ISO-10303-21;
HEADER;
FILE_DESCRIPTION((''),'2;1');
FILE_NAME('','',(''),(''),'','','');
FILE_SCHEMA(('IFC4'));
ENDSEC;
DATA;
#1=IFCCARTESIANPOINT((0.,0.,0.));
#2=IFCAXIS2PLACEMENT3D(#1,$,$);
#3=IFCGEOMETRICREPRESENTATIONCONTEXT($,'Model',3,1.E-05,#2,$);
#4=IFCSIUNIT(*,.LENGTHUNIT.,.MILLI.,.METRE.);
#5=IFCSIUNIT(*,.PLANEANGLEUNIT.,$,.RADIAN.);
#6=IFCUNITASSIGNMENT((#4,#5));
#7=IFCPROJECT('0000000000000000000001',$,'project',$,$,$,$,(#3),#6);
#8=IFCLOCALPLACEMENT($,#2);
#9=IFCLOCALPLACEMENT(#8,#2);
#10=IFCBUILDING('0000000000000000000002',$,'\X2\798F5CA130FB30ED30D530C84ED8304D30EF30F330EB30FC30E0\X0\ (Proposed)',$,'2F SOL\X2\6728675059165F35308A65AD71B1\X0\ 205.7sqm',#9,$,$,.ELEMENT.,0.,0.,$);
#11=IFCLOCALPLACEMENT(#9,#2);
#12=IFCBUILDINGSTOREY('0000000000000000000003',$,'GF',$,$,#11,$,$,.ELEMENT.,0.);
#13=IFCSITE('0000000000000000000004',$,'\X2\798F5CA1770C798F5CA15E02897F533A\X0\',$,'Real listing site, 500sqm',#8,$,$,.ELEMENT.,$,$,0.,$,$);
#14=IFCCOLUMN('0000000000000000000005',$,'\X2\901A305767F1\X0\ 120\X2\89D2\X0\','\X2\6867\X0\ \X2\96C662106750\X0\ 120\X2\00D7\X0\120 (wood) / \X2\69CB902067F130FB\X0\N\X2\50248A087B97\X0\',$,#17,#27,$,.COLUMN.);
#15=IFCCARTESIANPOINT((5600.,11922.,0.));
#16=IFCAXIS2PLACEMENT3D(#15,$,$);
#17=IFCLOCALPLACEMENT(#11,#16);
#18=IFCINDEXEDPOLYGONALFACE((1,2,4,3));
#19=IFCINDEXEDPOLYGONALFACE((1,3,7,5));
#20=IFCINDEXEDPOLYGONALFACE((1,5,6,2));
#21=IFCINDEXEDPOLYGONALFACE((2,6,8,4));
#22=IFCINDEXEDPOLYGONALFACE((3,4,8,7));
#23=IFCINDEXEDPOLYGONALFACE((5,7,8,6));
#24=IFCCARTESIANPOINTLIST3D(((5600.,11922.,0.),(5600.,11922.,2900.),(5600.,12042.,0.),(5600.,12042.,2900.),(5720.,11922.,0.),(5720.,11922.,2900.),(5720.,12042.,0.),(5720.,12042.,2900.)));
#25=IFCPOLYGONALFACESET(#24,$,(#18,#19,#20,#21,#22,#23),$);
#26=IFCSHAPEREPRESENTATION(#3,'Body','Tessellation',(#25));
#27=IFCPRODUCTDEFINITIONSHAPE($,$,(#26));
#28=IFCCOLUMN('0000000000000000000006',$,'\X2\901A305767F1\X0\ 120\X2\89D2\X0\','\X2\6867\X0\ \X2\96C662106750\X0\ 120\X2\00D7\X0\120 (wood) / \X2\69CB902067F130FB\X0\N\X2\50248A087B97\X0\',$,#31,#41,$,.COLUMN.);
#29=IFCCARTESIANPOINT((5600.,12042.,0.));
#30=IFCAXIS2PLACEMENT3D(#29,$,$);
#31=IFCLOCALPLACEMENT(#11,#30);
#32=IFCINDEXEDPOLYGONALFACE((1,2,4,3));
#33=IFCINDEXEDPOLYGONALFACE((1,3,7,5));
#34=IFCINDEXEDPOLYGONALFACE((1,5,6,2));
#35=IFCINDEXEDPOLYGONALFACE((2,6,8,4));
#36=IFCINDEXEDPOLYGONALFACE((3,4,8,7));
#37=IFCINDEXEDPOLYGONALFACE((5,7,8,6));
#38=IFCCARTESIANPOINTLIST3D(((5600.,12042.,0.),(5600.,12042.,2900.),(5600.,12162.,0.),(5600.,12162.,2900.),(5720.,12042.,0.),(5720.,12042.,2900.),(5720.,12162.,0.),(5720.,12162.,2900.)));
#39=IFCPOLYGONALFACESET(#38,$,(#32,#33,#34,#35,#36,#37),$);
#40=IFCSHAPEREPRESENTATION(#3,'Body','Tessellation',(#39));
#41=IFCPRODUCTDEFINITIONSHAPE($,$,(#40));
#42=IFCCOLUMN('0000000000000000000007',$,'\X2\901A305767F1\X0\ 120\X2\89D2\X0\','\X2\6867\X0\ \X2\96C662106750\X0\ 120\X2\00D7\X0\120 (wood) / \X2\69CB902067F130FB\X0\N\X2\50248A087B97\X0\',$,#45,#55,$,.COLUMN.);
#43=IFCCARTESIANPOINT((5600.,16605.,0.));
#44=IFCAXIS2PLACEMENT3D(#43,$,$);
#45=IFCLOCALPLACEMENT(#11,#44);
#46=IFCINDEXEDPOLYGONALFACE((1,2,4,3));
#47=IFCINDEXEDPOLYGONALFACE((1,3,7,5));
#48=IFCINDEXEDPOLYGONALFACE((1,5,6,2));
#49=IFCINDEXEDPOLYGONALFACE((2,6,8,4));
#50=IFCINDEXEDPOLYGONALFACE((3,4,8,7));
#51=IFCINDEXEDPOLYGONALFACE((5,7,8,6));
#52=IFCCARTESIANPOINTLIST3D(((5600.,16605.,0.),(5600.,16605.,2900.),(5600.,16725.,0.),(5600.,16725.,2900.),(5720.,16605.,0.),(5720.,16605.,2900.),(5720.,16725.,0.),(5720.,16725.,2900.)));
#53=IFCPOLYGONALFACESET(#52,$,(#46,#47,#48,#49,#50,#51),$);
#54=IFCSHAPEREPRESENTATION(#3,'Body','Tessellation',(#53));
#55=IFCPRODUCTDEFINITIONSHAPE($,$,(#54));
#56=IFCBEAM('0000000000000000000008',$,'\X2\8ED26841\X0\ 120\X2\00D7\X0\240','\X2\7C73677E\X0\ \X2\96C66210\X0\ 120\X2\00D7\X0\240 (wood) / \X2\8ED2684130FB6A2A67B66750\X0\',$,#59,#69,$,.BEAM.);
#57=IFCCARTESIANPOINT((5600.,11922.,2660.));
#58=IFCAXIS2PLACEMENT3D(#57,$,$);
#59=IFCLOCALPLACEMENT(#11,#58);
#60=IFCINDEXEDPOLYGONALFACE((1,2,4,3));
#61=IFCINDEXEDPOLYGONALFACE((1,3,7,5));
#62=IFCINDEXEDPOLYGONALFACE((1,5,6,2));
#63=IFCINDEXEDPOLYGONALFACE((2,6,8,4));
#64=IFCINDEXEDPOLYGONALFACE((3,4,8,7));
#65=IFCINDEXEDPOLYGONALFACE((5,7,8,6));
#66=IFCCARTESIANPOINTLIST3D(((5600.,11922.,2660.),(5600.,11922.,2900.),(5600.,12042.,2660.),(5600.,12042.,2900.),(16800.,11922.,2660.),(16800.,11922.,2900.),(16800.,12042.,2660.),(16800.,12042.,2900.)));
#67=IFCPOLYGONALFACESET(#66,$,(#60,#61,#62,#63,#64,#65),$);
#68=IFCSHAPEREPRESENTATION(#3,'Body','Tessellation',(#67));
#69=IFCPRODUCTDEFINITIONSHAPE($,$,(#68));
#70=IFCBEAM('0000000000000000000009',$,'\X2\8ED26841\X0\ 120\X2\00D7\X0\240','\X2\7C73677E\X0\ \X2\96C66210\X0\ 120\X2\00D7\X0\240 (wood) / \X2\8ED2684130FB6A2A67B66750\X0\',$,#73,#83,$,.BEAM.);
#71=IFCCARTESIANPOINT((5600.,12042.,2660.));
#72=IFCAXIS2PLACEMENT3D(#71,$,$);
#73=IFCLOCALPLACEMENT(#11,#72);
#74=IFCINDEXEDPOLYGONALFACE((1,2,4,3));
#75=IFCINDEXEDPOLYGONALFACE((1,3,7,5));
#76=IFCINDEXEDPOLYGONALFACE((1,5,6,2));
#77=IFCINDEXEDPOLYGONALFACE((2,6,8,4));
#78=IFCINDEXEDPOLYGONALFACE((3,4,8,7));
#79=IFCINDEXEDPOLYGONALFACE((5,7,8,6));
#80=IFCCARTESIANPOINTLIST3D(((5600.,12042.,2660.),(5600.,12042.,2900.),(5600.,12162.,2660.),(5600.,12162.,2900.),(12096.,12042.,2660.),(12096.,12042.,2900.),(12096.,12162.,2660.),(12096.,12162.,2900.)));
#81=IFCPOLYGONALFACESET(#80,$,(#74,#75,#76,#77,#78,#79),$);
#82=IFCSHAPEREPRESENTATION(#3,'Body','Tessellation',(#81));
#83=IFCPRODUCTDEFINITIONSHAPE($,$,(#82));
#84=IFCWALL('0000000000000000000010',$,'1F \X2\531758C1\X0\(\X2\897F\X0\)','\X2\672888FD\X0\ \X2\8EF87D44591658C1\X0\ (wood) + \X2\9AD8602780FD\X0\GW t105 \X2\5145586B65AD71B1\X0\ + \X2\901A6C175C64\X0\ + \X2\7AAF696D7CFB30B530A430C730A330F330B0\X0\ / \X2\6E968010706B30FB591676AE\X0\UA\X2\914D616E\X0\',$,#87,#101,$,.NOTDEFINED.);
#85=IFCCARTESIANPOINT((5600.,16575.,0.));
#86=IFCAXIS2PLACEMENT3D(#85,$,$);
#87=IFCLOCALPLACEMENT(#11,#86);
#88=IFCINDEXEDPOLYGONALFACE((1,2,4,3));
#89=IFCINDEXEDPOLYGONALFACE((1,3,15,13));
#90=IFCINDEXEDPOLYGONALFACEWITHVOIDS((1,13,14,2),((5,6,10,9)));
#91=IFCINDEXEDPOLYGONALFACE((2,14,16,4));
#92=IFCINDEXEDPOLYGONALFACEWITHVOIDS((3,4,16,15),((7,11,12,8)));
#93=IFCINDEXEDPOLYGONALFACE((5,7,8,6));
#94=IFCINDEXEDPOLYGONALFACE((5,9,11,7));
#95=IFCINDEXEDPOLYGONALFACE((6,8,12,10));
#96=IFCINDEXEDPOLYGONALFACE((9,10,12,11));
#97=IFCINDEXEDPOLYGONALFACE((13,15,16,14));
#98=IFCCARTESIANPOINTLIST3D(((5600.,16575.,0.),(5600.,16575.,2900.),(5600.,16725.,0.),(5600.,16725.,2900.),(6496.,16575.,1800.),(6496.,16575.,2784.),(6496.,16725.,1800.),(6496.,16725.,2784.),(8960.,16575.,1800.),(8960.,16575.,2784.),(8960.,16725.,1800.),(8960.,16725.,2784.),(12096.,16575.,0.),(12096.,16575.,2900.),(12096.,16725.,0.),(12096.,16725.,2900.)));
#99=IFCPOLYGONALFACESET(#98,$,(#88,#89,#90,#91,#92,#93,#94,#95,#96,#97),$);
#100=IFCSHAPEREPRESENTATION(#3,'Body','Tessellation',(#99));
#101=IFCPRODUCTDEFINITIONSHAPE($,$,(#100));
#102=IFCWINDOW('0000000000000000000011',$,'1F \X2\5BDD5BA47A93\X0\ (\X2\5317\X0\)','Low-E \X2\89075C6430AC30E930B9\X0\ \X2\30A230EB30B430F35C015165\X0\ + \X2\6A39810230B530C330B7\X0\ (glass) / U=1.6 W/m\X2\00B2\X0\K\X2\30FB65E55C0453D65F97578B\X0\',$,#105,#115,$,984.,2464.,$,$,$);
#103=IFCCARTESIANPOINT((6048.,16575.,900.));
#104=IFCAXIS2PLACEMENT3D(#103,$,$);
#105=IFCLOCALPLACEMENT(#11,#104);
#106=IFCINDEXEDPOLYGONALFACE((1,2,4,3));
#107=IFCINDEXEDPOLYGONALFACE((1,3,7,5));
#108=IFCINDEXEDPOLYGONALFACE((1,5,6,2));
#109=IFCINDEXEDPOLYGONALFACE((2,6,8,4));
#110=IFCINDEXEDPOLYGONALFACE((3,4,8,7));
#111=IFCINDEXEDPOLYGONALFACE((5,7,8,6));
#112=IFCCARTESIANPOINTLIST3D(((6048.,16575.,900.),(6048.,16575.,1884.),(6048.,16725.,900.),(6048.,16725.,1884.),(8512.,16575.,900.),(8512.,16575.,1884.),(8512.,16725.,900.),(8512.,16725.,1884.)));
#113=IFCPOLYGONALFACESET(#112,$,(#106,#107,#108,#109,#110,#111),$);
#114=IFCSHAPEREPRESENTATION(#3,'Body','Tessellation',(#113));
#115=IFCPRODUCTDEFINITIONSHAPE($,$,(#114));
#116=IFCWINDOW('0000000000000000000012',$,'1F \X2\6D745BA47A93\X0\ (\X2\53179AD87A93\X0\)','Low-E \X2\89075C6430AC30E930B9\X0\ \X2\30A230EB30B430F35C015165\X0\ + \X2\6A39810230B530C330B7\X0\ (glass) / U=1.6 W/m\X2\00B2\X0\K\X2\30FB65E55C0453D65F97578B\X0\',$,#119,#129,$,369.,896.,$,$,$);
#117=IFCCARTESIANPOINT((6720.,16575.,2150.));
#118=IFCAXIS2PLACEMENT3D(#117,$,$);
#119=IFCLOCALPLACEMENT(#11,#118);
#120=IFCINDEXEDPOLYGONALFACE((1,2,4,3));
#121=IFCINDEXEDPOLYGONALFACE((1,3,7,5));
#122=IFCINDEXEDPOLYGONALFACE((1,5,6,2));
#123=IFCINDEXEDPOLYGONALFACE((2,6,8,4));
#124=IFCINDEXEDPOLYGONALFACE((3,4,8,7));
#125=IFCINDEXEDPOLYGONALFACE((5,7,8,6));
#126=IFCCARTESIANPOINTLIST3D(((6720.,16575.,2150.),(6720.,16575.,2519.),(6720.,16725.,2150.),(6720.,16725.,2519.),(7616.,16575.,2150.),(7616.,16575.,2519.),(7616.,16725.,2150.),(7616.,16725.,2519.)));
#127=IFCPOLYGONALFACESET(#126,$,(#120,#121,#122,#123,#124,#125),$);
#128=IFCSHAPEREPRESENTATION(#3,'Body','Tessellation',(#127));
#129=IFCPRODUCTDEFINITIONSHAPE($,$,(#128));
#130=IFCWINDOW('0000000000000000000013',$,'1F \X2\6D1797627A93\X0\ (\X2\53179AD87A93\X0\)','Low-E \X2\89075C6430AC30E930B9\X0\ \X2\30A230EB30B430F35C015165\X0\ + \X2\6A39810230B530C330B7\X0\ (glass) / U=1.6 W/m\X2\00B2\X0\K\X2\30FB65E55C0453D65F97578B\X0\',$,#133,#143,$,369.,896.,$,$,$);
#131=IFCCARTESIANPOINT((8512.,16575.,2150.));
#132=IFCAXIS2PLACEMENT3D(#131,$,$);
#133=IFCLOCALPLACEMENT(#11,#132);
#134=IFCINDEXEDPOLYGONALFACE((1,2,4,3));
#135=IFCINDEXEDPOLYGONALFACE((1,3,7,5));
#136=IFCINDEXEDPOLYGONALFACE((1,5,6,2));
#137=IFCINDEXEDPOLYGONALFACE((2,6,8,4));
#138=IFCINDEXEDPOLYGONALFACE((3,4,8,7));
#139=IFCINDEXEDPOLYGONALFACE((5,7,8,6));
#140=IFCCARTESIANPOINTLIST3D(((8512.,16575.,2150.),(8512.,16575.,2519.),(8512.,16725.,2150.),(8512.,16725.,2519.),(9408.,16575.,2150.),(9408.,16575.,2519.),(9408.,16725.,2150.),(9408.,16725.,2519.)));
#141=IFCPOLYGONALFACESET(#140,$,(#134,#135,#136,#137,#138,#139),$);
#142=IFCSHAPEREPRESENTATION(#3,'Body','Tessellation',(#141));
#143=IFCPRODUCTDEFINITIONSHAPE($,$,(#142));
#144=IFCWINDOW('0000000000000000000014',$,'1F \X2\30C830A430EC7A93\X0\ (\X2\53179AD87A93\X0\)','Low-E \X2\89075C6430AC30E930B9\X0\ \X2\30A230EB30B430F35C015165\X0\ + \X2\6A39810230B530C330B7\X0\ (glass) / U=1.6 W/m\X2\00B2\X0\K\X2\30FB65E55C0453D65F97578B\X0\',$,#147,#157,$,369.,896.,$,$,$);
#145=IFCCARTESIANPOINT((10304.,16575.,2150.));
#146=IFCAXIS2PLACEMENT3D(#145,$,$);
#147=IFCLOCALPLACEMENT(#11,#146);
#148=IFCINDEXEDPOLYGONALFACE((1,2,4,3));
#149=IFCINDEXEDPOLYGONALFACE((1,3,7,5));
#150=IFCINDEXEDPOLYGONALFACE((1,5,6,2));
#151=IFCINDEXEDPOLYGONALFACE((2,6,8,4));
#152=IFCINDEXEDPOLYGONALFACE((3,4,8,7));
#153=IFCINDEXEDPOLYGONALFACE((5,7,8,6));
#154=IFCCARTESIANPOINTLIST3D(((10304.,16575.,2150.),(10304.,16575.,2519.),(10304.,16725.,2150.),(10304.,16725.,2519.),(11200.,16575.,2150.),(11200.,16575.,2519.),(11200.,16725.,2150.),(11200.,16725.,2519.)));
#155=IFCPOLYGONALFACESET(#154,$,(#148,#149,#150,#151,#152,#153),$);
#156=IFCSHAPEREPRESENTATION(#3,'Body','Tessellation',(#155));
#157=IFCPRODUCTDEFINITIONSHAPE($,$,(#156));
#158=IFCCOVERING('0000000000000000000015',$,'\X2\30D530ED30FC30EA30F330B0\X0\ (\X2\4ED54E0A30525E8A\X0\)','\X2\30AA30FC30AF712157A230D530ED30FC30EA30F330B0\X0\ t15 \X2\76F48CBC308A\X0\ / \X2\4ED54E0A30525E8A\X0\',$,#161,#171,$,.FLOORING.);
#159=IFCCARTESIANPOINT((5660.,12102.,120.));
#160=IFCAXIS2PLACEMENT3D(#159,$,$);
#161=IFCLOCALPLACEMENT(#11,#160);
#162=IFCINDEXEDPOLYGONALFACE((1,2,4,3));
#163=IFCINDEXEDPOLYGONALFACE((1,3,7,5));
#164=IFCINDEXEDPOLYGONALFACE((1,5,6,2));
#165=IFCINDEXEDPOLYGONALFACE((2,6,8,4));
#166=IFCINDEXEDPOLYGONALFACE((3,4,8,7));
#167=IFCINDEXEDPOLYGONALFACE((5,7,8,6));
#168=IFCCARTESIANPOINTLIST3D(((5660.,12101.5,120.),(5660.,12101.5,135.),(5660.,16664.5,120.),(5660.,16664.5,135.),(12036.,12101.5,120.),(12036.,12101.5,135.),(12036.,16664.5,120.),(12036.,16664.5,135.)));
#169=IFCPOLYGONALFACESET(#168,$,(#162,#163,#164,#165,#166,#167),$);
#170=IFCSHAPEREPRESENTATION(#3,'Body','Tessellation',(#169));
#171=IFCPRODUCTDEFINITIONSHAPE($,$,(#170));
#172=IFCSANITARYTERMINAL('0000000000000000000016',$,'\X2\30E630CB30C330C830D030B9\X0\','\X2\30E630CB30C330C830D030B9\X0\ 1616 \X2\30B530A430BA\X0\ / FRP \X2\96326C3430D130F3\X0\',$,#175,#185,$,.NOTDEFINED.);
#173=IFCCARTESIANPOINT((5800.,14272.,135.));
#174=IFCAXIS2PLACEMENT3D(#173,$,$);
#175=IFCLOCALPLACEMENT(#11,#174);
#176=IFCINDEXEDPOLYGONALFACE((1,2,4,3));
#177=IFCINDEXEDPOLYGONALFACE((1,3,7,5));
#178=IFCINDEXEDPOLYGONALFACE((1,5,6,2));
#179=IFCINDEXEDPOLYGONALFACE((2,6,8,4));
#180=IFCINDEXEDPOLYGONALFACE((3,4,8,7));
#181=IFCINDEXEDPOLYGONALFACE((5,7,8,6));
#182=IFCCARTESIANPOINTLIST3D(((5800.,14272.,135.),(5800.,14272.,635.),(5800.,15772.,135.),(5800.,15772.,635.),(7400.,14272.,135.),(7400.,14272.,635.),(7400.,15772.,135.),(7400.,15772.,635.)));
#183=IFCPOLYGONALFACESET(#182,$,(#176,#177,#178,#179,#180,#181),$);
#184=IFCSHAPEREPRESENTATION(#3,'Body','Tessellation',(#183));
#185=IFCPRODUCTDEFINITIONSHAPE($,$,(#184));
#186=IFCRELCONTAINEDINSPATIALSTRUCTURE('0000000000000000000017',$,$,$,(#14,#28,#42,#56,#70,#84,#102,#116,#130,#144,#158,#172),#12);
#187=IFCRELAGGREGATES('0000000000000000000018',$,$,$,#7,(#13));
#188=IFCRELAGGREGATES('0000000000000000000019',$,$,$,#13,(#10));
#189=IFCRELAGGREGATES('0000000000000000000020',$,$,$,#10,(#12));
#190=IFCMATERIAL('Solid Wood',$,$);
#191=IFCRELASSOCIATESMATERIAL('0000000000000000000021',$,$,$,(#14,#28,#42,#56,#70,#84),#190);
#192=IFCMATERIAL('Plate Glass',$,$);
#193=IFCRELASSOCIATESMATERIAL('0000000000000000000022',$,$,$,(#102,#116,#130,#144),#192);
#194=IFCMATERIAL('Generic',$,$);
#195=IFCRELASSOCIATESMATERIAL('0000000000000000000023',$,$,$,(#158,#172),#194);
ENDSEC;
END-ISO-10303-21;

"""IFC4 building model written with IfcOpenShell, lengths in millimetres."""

from ifc_helpers import new_model, si_unit, frame, frame_2d, origin, place, context, project, spatial, rectangle, extrude, material, element, fill, save


model = new_model("IFC4")

# Units and contexts
model_context = context("Model", 3, precision=1e-05, world=origin())
ifc_project = project(units=[si_unit("LENGTHUNIT", "METRE", prefix="MILLI"), si_unit("PLANEANGLEUNIT", "RADIAN")], contexts=[model_context])

# Site, building, storey
site_placement = place(None, origin())
site = spatial("IfcSite", under=ifc_project, at=site_placement, Name="福岡県福岡市西区", ObjectType="Real listing site, 500sqm", CompositionType="ELEMENT", RefElevation=0.0)
building_placement = place(site_placement, origin())
building = spatial("IfcBuilding", under=site, at=building_placement, Name="福岡・ロフト付きワンルーム (Proposed)", ObjectType="2F SOL木材外張り断熱 205.7sqm", CompositionType="ELEMENT", ElevationOfRefHeight=0.0, ElevationOfTerrain=0.0)
storey_placement = place(building_placement, origin())
storey = spatial("IfcBuildingStorey", under=building, at=storey_placement, Name="GF", CompositionType="ELEMENT", Elevation=0.0)

# Columns
ifc_material_1 = material(Name="Solid Wood")
column_1_placement = place(storey_placement, frame((5600.0, 11922.0, 0.0)))
element("IfcColumn", 1, at=column_1_placement, inside=storey, material=ifc_material_1, Name="通し柱 120角", Description="桧 集成材 120×120 (wood) / 構造柱・N値計算", PredefinedType="COLUMN", context=model_context, shape_type="SweptSolid", body=[
    extrude(rectangle(XDim=120.0, YDim=120.0, at=frame_2d((60.0, 60.0))), frame((5600.0, 11922.0, 0.0)), (0.0, 0.0, 1.0), 2900.0),
])
column_2_placement = place(storey_placement, frame((5600.0, 12042.0, 0.0)))
element("IfcColumn", 2, at=column_2_placement, inside=storey, material=ifc_material_1, Name="通し柱 120角", Description="桧 集成材 120×120 (wood) / 構造柱・N値計算", PredefinedType="COLUMN", context=model_context, shape_type="SweptSolid", body=[
    extrude(rectangle(XDim=120.0, YDim=120.0, at=frame_2d((60.0, 60.0))), frame((5600.0, 12042.0, 0.0)), (0.0, 0.0, 1.0), 2900.0),
])
column_3_placement = place(storey_placement, frame((5600.0, 16605.0, 0.0)))
element("IfcColumn", 3, at=column_3_placement, inside=storey, material=ifc_material_1, Name="通し柱 120角", Description="桧 集成材 120×120 (wood) / 構造柱・N値計算", PredefinedType="COLUMN", context=model_context, shape_type="SweptSolid", body=[
    extrude(rectangle(XDim=120.0, YDim=120.0, at=frame_2d((60.0, 60.0))), frame((5600.0, 16605.0, 0.0)), (0.0, 0.0, 1.0), 2900.0),
])

# Beams
beam_1_placement = place(storey_placement, frame((5600.0, 11922.0, 2660.0)))
element("IfcBeam", 4, at=beam_1_placement, inside=storey, material=ifc_material_1, Name="軒桁 120×240", Description="米松 集成 120×240 (wood) / 軒桁・横架材", PredefinedType="BEAM", context=model_context, shape_type="SweptSolid", body=[
    extrude(rectangle(XDim=11200.0, YDim=120.0, at=frame_2d((5600.0, 60.0))), frame((5600.0, 11922.0, 2660.0)), (0.0, 0.0, 1.0), 240.0),
])
beam_2_placement = place(storey_placement, frame((5600.0, 12042.0, 2660.0)))
element("IfcBeam", 5, at=beam_2_placement, inside=storey, material=ifc_material_1, Name="軒桁 120×240", Description="米松 集成 120×240 (wood) / 軒桁・横架材", PredefinedType="BEAM", context=model_context, shape_type="SweptSolid", body=[
    extrude(rectangle(XDim=6496.0, YDim=120.0, at=frame_2d((3248.0, 60.0))), frame((5600.0, 12042.0, 2660.0)), (0.0, 0.0, 1.0), 240.0),
])

# Wall, openings, windows
wall_1_placement = place(storey_placement, frame((5600.0, 16575.0, 0.0)))
wall_1 = element("IfcWall", 6, at=wall_1_placement, inside=storey, material=ifc_material_1, Name="1F 北壁(西)", Description="木製 軸組外壁 (wood) + 高性能GW t105 充填断熱 + 通気層 + 窯業系サイディング / 準耐火・外皮UA配慮", PredefinedType="NOTDEFINED", context=model_context, shape_type="SweptSolid", body=[
    extrude(rectangle(XDim=6496.0, YDim=150.0, at=frame_2d((3248.0, 75.0))), frame((5600.0, 16575.0, 0.0)), (0.0, 0.0, 1.0), 2900.0),
])
opening_1_placement = place(storey_placement, frame((6048.0, 16575.0, 900.0)))
opening_1 = element("IfcOpeningElement", 7, at=opening_1_placement, cuts=wall_1, PredefinedType="NOTDEFINED", context=model_context, shape_type="SweptSolid", body=[
    extrude(rectangle(XDim=2464.0, YDim=150.0, at=frame_2d((1232.0, 75.0))), frame((6048.0, 16575.0, 900.0)), (0.0, 0.0, 1.0), 984.0),
])
opening_2_placement = place(storey_placement, frame((6720.0, 16575.0, 2150.0)))
opening_2 = element("IfcOpeningElement", 8, at=opening_2_placement, cuts=wall_1, PredefinedType="NOTDEFINED", context=model_context, shape_type="SweptSolid", body=[
    extrude(rectangle(XDim=896.0, YDim=150.0, at=frame_2d((448.0, 75.0))), frame((6720.0, 16575.0, 2150.0)), (0.0, 0.0, 1.0), 369.0),
])
opening_3_placement = place(storey_placement, frame((8512.0, 16575.0, 2150.0)))
opening_3 = element("IfcOpeningElement", 9, at=opening_3_placement, cuts=wall_1, PredefinedType="NOTDEFINED", context=model_context, shape_type="SweptSolid", body=[
    extrude(rectangle(XDim=896.0, YDim=150.0, at=frame_2d((448.0, 75.0))), frame((8512.0, 16575.0, 2150.0)), (0.0, 0.0, 1.0), 369.0),
])
opening_4_placement = place(storey_placement, frame((10304.0, 16575.0, 2150.0)))
opening_4 = element("IfcOpeningElement", 10, at=opening_4_placement, cuts=wall_1, PredefinedType="NOTDEFINED", context=model_context, shape_type="SweptSolid", body=[
    extrude(rectangle(XDim=896.0, YDim=150.0, at=frame_2d((448.0, 75.0))), frame((10304.0, 16575.0, 2150.0)), (0.0, 0.0, 1.0), 369.0),
])
ifc_material_2 = material(Name="Plate Glass")
window_1_placement = place(storey_placement, frame((6048.0, 16575.0, 900.0)))
window_1 = element("IfcWindow", 11, at=window_1_placement, inside=storey, material=ifc_material_2, Name="1F 寝室窓 (北)", Description="Low-E 複層ガラス アルゴン封入 + 樹脂サッシ (glass) / U=1.6 W/m²K・日射取得型", OverallHeight=984.0, OverallWidth=2464.0, context=model_context, shape_type="SweptSolid", body=[
    extrude(rectangle(XDim=2464.0, YDim=150.0, at=frame_2d((1232.0, 75.0))), frame((6048.0, 16575.0, 900.0)), (0.0, 0.0, 1.0), 984.0),
])
fill(opening_1, window_1)
window_2_placement = place(storey_placement, frame((6720.0, 16575.0, 2150.0)))
window_2 = element("IfcWindow", 12, at=window_2_placement, inside=storey, material=ifc_material_2, Name="1F 浴室窓 (北高窓)", Description="Low-E 複層ガラス アルゴン封入 + 樹脂サッシ (glass) / U=1.6 W/m²K・日射取得型", OverallHeight=369.0, OverallWidth=896.0, context=model_context, shape_type="SweptSolid", body=[
    extrude(rectangle(XDim=896.0, YDim=150.0, at=frame_2d((448.0, 75.0))), frame((6720.0, 16575.0, 2150.0)), (0.0, 0.0, 1.0), 369.0),
])
fill(opening_2, window_2)
window_3_placement = place(storey_placement, frame((8512.0, 16575.0, 2150.0)))
window_3 = element("IfcWindow", 13, at=window_3_placement, inside=storey, material=ifc_material_2, Name="1F 洗面窓 (北高窓)", Description="Low-E 複層ガラス アルゴン封入 + 樹脂サッシ (glass) / U=1.6 W/m²K・日射取得型", OverallHeight=369.0, OverallWidth=896.0, context=model_context, shape_type="SweptSolid", body=[
    extrude(rectangle(XDim=896.0, YDim=150.0, at=frame_2d((448.0, 75.0))), frame((8512.0, 16575.0, 2150.0)), (0.0, 0.0, 1.0), 369.0),
])
fill(opening_3, window_3)
window_4_placement = place(storey_placement, frame((10304.0, 16575.0, 2150.0)))
window_4 = element("IfcWindow", 14, at=window_4_placement, inside=storey, material=ifc_material_2, Name="1F トイレ窓 (北高窓)", Description="Low-E 複層ガラス アルゴン封入 + 樹脂サッシ (glass) / U=1.6 W/m²K・日射取得型", OverallHeight=369.0, OverallWidth=896.0, context=model_context, shape_type="SweptSolid", body=[
    extrude(rectangle(XDim=896.0, YDim=150.0, at=frame_2d((448.0, 75.0))), frame((10304.0, 16575.0, 2150.0)), (0.0, 0.0, 1.0), 369.0),
])
fill(opening_4, window_4)

# Covering
ifc_material_3 = material(Name="Generic")
covering_placement = place(storey_placement, frame((5660.0, 12102.0, 120.0)))
element("IfcCovering", 15, at=covering_placement, inside=storey, material=ifc_material_3, Name="フローリング (仕上げ床)", Description="オーク無垢フローリング t15 直貼り / 仕上げ床", PredefinedType="FLOORING", context=model_context, shape_type="SweptSolid", body=[
    extrude(rectangle(XDim=6376.0, YDim=4563.0, at=frame_2d((3188.0, 2281.0))), frame((5660.0, 12102.0, 120.0)), (0.0, 0.0, 1.0), 15.0),
])

# Sanitary terminal
sanitary_terminal_placement = place(storey_placement, frame((5800.0, 14272.0, 135.0)))
element("IfcSanitaryTerminal", 16, at=sanitary_terminal_placement, inside=storey, material=ifc_material_3, Name="ユニットバス", Description="ユニットバス 1616 サイズ / FRP 防水パン", PredefinedType="NOTDEFINED", context=model_context, shape_type="SweptSolid", body=[
    extrude(rectangle(XDim=1600.0, YDim=1500.0, at=frame_2d((800.0, 750.0))), frame((5800.0, 14272.0, 135.0)), (0.0, 0.0, 1.0), 500.0),
])

save(model, "model.ifc")
